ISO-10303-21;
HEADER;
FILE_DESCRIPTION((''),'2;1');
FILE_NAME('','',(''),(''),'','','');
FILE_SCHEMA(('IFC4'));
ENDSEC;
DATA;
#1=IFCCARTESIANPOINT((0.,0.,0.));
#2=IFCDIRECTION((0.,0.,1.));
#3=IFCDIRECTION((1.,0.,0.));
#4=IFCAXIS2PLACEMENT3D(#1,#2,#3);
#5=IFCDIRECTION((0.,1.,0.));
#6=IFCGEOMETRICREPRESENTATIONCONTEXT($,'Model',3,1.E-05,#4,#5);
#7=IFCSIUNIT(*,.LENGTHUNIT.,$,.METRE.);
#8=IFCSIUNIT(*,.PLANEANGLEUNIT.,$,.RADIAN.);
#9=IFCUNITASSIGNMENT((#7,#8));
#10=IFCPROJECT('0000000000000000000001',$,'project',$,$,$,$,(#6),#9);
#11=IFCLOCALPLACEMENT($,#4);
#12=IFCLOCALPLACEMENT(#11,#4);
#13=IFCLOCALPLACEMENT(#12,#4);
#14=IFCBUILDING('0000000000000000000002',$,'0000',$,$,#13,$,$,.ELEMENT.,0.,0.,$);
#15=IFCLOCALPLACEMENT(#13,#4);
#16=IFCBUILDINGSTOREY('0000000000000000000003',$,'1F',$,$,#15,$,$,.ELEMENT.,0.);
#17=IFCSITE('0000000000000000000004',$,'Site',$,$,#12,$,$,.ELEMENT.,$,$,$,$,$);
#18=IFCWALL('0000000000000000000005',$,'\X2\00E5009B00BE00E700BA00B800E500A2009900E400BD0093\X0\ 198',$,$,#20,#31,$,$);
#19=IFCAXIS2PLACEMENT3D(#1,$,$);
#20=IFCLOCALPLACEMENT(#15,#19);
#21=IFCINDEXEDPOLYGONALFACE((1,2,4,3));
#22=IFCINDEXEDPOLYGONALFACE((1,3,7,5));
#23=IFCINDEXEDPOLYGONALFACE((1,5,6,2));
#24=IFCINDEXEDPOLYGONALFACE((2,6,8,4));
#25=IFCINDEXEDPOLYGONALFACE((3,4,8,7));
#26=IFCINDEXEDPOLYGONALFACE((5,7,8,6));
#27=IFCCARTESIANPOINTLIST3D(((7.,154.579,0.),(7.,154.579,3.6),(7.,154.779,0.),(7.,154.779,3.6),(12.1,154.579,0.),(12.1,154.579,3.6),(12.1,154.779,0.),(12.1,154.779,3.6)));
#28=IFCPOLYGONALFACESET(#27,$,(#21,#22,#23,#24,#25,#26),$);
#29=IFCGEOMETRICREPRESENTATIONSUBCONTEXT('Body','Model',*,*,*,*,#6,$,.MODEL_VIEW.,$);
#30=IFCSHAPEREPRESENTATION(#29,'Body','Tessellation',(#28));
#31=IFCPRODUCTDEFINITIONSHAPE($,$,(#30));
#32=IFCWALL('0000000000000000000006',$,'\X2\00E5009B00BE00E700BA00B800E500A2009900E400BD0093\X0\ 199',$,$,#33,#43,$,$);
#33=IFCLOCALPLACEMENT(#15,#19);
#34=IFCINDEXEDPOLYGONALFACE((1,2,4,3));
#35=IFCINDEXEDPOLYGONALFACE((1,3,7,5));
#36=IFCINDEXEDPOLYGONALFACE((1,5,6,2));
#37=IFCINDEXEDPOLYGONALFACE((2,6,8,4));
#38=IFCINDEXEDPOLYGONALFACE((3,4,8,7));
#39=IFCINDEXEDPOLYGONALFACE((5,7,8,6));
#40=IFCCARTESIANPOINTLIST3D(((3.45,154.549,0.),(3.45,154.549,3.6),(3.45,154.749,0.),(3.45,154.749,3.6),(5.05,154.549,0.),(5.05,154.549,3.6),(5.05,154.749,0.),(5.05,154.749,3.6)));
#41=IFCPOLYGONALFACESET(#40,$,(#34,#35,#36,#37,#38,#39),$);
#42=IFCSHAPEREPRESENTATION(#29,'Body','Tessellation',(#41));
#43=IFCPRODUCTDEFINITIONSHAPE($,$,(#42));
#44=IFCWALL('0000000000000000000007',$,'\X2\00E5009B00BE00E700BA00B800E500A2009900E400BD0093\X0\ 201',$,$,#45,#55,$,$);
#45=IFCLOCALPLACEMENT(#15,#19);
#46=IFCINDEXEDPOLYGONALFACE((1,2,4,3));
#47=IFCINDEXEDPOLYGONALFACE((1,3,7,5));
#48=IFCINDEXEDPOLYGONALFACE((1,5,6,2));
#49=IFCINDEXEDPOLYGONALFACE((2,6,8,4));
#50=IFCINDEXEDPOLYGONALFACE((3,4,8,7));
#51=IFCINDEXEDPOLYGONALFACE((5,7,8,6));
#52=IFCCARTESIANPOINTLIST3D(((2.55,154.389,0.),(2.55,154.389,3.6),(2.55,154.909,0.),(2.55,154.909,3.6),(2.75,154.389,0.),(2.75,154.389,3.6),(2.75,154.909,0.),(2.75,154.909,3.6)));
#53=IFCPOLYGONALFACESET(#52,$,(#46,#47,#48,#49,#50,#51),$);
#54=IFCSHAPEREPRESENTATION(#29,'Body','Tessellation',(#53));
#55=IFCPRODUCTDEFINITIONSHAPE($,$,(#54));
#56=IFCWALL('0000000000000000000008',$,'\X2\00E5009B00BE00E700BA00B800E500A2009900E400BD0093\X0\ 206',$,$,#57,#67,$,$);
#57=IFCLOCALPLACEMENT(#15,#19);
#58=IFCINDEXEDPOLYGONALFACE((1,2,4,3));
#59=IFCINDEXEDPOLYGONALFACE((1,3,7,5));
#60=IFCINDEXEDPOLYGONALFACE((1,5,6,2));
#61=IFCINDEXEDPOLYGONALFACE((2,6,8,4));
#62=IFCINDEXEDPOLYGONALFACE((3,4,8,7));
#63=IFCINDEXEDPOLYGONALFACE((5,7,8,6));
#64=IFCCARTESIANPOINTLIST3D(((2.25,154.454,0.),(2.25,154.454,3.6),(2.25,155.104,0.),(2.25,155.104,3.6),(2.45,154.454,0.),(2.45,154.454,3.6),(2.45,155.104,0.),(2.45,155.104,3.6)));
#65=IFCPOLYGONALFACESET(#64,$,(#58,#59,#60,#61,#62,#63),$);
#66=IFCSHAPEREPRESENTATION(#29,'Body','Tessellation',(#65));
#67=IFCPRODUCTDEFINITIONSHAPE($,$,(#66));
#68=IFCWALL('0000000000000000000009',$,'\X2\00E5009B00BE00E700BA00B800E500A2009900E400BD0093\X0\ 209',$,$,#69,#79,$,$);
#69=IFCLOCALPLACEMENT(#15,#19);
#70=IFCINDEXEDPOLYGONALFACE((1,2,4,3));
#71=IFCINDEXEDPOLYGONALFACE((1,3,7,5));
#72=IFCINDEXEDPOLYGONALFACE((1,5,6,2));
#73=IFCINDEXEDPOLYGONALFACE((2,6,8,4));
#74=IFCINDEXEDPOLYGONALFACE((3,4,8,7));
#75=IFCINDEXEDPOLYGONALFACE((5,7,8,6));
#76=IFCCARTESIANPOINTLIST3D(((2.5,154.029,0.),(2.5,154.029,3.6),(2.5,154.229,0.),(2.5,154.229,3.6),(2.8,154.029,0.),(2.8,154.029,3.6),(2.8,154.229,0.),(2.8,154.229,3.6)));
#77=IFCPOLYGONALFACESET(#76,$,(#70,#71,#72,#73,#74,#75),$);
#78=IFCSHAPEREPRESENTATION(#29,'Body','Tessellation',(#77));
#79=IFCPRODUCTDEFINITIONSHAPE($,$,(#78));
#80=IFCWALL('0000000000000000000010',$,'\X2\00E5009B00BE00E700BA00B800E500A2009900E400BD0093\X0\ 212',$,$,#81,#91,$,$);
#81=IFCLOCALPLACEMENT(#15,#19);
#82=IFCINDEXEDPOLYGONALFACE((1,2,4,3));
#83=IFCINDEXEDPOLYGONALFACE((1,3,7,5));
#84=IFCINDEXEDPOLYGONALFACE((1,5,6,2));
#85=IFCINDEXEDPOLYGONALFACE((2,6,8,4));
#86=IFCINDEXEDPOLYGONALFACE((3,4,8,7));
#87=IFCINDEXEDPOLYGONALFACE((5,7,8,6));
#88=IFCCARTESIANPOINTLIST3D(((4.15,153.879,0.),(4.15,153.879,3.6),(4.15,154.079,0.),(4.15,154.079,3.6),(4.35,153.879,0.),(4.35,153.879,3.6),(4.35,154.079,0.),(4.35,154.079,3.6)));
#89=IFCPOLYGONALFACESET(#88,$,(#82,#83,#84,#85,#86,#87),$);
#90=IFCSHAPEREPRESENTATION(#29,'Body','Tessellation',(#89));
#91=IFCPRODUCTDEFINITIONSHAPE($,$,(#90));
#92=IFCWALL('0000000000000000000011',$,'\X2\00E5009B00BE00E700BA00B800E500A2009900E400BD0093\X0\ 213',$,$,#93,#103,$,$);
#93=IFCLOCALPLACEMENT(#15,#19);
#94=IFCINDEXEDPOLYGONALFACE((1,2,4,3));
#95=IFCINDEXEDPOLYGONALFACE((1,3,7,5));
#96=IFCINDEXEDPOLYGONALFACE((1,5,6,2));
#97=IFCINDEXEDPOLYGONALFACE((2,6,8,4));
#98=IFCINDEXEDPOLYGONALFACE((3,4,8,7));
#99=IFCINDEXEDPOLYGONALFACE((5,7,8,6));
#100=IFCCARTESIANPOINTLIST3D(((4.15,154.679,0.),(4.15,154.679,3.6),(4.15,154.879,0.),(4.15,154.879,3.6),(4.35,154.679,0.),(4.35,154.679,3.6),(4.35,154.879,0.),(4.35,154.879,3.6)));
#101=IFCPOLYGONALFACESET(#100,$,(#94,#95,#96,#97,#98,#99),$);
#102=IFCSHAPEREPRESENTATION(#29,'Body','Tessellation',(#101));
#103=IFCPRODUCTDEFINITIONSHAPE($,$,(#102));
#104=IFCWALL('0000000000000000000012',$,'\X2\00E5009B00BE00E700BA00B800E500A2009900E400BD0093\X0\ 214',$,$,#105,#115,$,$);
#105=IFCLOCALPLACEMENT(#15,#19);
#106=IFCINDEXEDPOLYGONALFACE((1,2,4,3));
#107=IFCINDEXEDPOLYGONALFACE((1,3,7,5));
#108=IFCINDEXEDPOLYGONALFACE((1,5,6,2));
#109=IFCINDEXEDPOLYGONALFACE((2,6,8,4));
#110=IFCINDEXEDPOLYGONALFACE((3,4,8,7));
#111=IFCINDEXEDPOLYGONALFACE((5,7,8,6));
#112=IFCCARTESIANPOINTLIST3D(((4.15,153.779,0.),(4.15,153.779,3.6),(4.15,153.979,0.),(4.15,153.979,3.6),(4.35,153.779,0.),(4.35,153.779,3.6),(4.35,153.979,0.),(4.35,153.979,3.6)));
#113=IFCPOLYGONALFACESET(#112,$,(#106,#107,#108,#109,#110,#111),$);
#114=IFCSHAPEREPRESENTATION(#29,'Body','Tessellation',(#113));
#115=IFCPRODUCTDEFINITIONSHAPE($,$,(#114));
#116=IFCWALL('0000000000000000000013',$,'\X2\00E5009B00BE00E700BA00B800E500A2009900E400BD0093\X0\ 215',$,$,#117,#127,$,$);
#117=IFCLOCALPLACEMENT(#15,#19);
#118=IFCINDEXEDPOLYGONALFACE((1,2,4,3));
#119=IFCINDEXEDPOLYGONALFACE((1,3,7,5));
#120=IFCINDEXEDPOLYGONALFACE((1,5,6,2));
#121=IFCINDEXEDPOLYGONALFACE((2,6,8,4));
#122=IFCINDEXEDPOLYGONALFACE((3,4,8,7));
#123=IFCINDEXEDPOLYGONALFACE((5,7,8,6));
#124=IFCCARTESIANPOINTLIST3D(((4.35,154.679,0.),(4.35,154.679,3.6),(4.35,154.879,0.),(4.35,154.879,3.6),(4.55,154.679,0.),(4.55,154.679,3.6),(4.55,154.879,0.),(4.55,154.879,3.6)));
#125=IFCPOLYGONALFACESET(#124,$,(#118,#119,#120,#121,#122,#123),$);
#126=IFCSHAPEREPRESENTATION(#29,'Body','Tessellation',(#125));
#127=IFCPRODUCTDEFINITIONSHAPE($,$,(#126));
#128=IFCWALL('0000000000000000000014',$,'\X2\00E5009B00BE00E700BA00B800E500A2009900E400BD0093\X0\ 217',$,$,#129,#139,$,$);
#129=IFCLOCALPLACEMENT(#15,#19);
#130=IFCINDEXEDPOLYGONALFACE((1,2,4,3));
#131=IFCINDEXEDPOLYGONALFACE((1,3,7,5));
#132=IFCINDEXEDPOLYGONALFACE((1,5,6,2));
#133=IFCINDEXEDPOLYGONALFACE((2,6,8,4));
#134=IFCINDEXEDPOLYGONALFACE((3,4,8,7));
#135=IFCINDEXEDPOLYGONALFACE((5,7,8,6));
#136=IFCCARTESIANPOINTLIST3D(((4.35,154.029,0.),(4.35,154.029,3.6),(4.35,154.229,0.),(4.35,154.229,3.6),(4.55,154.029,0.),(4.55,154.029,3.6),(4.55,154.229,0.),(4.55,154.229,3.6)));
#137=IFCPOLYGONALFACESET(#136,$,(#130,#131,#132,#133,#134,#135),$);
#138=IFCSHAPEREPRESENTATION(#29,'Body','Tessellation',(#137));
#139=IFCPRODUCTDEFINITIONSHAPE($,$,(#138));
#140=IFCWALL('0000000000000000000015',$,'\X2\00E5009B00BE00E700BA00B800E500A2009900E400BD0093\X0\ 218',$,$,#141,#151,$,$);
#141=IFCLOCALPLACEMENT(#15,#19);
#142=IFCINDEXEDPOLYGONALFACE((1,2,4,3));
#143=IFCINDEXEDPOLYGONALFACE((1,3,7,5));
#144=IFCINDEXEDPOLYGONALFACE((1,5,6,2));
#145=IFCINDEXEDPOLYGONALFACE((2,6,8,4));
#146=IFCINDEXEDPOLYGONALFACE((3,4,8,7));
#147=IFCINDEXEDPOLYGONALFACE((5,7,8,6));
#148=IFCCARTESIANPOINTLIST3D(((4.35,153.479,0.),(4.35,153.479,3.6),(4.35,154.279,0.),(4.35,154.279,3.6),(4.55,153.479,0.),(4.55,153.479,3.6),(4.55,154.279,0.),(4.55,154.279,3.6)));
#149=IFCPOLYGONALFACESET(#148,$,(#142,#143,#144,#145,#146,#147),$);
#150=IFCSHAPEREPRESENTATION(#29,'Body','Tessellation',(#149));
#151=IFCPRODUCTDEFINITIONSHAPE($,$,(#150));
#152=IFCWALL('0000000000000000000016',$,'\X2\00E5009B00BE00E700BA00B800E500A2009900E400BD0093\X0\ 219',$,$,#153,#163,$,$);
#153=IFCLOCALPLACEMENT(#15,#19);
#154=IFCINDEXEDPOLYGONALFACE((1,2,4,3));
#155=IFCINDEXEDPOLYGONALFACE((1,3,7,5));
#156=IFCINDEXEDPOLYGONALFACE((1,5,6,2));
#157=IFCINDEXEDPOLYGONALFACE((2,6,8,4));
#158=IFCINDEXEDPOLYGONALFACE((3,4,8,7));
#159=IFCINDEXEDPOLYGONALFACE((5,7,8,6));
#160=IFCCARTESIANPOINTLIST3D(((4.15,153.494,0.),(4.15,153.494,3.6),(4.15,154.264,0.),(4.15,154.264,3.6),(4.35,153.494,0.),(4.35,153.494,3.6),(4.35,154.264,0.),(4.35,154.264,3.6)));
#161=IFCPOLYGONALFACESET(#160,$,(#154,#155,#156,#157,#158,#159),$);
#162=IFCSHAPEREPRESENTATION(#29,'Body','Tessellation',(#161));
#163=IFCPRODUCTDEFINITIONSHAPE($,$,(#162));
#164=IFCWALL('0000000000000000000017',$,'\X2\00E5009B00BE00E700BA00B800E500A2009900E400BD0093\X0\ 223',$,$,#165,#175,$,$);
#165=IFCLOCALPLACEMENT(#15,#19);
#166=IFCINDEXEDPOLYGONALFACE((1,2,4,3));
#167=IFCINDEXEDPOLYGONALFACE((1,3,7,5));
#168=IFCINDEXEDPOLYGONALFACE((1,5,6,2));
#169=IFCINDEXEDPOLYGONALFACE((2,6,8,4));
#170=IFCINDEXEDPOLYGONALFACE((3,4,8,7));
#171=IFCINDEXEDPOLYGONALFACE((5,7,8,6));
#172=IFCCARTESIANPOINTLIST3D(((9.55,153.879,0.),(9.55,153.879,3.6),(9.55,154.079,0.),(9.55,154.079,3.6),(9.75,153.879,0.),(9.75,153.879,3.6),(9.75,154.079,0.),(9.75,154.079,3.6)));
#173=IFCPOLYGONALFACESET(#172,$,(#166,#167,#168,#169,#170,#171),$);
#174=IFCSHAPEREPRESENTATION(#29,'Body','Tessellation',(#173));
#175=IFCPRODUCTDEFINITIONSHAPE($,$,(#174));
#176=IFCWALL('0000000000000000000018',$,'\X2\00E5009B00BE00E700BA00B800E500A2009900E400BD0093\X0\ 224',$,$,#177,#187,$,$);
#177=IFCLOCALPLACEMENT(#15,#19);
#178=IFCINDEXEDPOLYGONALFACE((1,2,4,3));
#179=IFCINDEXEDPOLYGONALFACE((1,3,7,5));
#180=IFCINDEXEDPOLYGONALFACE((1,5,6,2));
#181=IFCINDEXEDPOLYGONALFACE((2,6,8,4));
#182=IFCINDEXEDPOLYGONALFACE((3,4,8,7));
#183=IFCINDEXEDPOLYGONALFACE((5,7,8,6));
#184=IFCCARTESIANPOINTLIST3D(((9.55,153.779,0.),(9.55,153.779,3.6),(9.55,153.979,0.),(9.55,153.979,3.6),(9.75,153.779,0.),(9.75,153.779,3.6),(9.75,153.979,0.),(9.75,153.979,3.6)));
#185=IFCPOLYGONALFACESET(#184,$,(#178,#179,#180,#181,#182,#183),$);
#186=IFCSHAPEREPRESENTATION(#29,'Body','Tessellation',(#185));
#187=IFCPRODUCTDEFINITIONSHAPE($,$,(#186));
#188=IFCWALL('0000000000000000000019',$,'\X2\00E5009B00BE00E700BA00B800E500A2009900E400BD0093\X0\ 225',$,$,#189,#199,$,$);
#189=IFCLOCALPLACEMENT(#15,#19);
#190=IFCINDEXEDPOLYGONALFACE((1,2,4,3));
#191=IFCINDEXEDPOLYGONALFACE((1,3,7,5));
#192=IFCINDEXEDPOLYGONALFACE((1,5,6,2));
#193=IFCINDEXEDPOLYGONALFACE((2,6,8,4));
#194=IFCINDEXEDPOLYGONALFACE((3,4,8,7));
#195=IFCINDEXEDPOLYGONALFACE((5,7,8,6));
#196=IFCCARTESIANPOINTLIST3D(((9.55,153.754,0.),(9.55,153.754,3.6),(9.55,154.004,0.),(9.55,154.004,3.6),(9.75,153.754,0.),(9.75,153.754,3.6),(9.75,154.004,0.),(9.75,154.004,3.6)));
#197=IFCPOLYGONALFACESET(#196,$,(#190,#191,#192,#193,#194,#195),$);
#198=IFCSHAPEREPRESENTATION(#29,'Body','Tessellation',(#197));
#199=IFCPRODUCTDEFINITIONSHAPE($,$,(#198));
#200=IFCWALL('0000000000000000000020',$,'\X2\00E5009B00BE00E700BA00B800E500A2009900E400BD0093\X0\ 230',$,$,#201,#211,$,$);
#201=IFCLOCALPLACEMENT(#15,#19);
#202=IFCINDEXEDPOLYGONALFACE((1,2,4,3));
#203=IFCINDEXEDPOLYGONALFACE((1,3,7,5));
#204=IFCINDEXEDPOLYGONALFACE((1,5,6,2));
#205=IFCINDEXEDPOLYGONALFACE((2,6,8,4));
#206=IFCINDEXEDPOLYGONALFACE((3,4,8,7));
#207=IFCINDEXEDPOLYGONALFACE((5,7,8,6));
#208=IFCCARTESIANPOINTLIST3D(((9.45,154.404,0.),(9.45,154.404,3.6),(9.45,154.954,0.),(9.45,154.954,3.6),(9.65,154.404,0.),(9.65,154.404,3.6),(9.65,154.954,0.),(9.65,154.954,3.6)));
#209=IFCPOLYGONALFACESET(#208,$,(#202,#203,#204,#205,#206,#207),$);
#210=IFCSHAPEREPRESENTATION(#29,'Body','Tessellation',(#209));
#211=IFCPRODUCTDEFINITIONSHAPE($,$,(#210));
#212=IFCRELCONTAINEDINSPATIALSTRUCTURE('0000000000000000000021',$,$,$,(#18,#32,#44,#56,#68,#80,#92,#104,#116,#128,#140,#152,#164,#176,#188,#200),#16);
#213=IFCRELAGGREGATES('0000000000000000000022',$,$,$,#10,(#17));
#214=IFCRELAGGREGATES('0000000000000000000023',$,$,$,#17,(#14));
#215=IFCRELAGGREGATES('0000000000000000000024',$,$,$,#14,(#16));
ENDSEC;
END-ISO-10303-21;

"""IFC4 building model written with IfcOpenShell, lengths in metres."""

from ifc_helpers import new_model, si_unit, direction, frame, frame_2d, origin_with_axes, place, context, subcontext, project, spatial, rectangle, extrude, element, save


model = new_model("IFC4")

# Units and contexts
model_context = context("Model", 3, precision=1e-05, world=origin_with_axes(), true_north=direction((0.0, 1.0, 0.0)))
body_context = subcontext(model_context, "Body", "Model", "MODEL_VIEW")
ifc_project = project(units=[si_unit("LENGTHUNIT", "METRE"), si_unit("PLANEANGLEUNIT", "RADIAN")], contexts=[model_context])

# Site, building, storey
placement = place(None, origin_with_axes())
site_placement = place(placement, origin_with_axes())
site = spatial("IfcSite", under=ifc_project, at=site_placement, Name="Site", CompositionType="ELEMENT")
building_placement = place(site_placement, origin_with_axes())
building = spatial("IfcBuilding", under=site, at=building_placement, Name="0000", CompositionType="ELEMENT", ElevationOfRefHeight=0.0, ElevationOfTerrain=0.0)
storey_placement = place(building_placement, origin_with_axes())
storey = spatial("IfcBuildingStorey", under=building, at=storey_placement, Name="1F", CompositionType="ELEMENT", Elevation=0.0)

# Walls
wall_1_placement = place(storey_placement, frame((9.55, 154.679, 0.0), z_axis=(0.0, 0.0, 1.0), x_axis=(-1.0, 0.0, 0.0)))
element("IfcWall", 1, at=wall_1_placement, inside=storey, Name="å\u009b¾çº¸å¢\u0099ä½\u0093 198", context=body_context, shape_type="SweptSolid", body=[
    extrude(rectangle(XDim=5.1, YDim=0.2, at=frame_2d((0.0, 0.0), x_axis=(1.0, 0.0, 0.0))), frame((0.0, 0.0, 0.0), z_axis=(0.0, 0.0, 1.0)), (0.0, 0.0, 1.0), 3.6),
])
wall_2_placement = place(storey_placement, frame((4.25, 154.649, 0.0), z_axis=(0.0, 0.0, 1.0), x_axis=(-1.0, 0.0, 0.0)))
element("IfcWall", 2, at=wall_2_placement, inside=storey, Name="å\u009b¾çº¸å¢\u0099ä½\u0093 199", context=body_context, shape_type="SweptSolid", body=[
    extrude(rectangle(XDim=1.6, YDim=0.2, at=frame_2d((0.0, 0.0), x_axis=(1.0, 0.0, 0.0))), frame((0.0, 0.0, 0.0), z_axis=(0.0, 0.0, 1.0)), (0.0, 0.0, 1.0), 3.6),
])
wall_3_placement = place(storey_placement, frame((2.65, 154.649, 0.0), z_axis=(0.0, 0.0, 1.0), x_axis=(0.0, -1.0, 0.0)))
element("IfcWall", 3, at=wall_3_placement, inside=storey, Name="å\u009b¾çº¸å¢\u0099ä½\u0093 201", context=body_context, shape_type="SweptSolid", body=[
    extrude(rectangle(XDim=0.52, YDim=0.2, at=frame_2d((0.0, 0.0), x_axis=(1.0, 0.0, 0.0))), frame((0.0, 0.0, 0.0), z_axis=(0.0, 0.0, 1.0)), (0.0, 0.0, 1.0), 3.6),
])
wall_4_placement = place(storey_placement, frame((2.35, 154.779, 0.0), z_axis=(0.0, 0.0, 1.0), x_axis=(0.0, -1.0, 0.0)))
element("IfcWall", 4, at=wall_4_placement, inside=storey, Name="å\u009b¾çº¸å¢\u0099ä½\u0093 206", context=body_context, shape_type="SweptSolid", body=[
    extrude(rectangle(XDim=0.65, YDim=0.2, at=frame_2d((0.0, 0.0), x_axis=(1.0, 0.0, 0.0))), frame((0.0, 0.0, 0.0), z_axis=(0.0, 0.0, 1.0)), (0.0, 0.0, 1.0), 3.6),
])
wall_5_placement = place(storey_placement, frame((2.65, 154.129, 0.0), z_axis=(0.0, 0.0, 1.0), x_axis=(-1.0, 0.0, 0.0)))
element("IfcWall", 5, at=wall_5_placement, inside=storey, Name="å\u009b¾çº¸å¢\u0099ä½\u0093 209", context=body_context, shape_type="SweptSolid", body=[
    extrude(rectangle(XDim=0.3, YDim=0.2, at=frame_2d((0.0, 0.0), x_axis=(1.0, 0.0, 0.0))), frame((0.0, 0.0, 0.0), z_axis=(0.0, 0.0, 1.0)), (0.0, 0.0, 1.0), 3.6),
])
for number, where, z_axis, x_axis, name in (
    (6, (4.25, 153.979, 0.0), (0.0, 0.0, 1.0), (1.0, 0.0, 0.0), "å\u009b¾çº¸å¢\u0099ä½\u0093 212"),
    (7, (4.25, 154.779, 0.0), (0.0, 0.0, 1.0), (1.0, 0.0, 0.0), "å\u009b¾çº¸å¢\u0099ä½\u0093 213"),
    (8, (4.25, 153.879, 0.0), (0.0, 0.0, 1.0), (1.0, 0.0, 0.0), "å\u009b¾çº¸å¢\u0099ä½\u0093 214"),
    (9, (4.45, 154.779, 0.0), (0.0, 0.0, 1.0), (-1.0, 0.0, 0.0), "å\u009b¾çº¸å¢\u0099ä½\u0093 215"),
    (10, (4.45, 154.129, 0.0), (0.0, 0.0, 1.0), (-1.0, 0.0, 0.0), "å\u009b¾çº¸å¢\u0099ä½\u0093 217"),
):
    element("IfcWall", number, at=place(storey_placement, frame(where, z_axis=z_axis, x_axis=x_axis)), inside=storey, Name=name, context=body_context, shape_type="SweptSolid", body=[
        extrude(rectangle(XDim=0.2, YDim=0.2, at=frame_2d((0.0, 0.0), x_axis=(1.0, 0.0, 0.0))), frame((0.0, 0.0, 0.0), z_axis=(0.0, 0.0, 1.0)), (0.0, 0.0, 1.0), 3.6),
    ])
wall_6_placement = place(storey_placement, frame((4.45, 153.879, 0.0), z_axis=(0.0, 0.0, 1.0), x_axis=(0.0, 1.0, 0.0)))
element("IfcWall", 11, at=wall_6_placement, inside=storey, Name="å\u009b¾çº¸å¢\u0099ä½\u0093 218", context=body_context, shape_type="SweptSolid", body=[
    extrude(rectangle(XDim=0.8, YDim=0.2, at=frame_2d((0.0, 0.0), x_axis=(1.0, 0.0, 0.0))), frame((0.0, 0.0, 0.0), z_axis=(0.0, 0.0, 1.0)), (0.0, 0.0, 1.0), 3.6),
])
wall_7_placement = place(storey_placement, frame((4.25, 153.879, 0.0), z_axis=(0.0, 0.0, 1.0), x_axis=(0.0, 1.0, 0.0)))
element("IfcWall", 12, at=wall_7_placement, inside=storey, Name="å\u009b¾çº¸å¢\u0099ä½\u0093 219", context=body_context, shape_type="SweptSolid", body=[
    extrude(rectangle(XDim=0.77, YDim=0.2, at=frame_2d((0.0, 0.0), x_axis=(1.0, 0.0, 0.0))), frame((0.0, 0.0, 0.0), z_axis=(0.0, 0.0, 1.0)), (0.0, 0.0, 1.0), 3.6),
])
for number, where, z_axis, x_axis, name in (
    (13, (9.65, 153.979, 0.0), (0.0, 0.0, 1.0), (1.0, 0.0, 0.0), "å\u009b¾çº¸å¢\u0099ä½\u0093 223"),
    (14, (9.65, 153.879, 0.0), (0.0, 0.0, 1.0), (1.0, 0.0, 0.0), "å\u009b¾çº¸å¢\u0099ä½\u0093 224"),
):
    element("IfcWall", number, at=place(storey_placement, frame(where, z_axis=z_axis, x_axis=x_axis)), inside=storey, Name=name, context=body_context, shape_type="SweptSolid", body=[
        extrude(rectangle(XDim=0.2, YDim=0.2, at=frame_2d((0.0, 0.0), x_axis=(1.0, 0.0, 0.0))), frame((0.0, 0.0, 0.0), z_axis=(0.0, 0.0, 1.0)), (0.0, 0.0, 1.0), 3.6),
    ])
wall_8_placement = place(storey_placement, frame((9.65, 153.879, 0.0), z_axis=(0.0, 0.0, 1.0), x_axis=(0.0, 1.0, 0.0)))
element("IfcWall", 15, at=wall_8_placement, inside=storey, Name="å\u009b¾çº¸å¢\u0099ä½\u0093 225", context=body_context, shape_type="SweptSolid", body=[
    extrude(rectangle(XDim=0.25, YDim=0.2, at=frame_2d((0.0, 0.0), x_axis=(1.0, 0.0, 0.0))), frame((0.0, 0.0, 0.0), z_axis=(0.0, 0.0, 1.0)), (0.0, 0.0, 1.0), 3.6),
])
wall_9_placement = place(storey_placement, frame((9.55, 154.679, 0.0), z_axis=(0.0, 0.0, 1.0), x_axis=(0.0, -1.0, 0.0)))
element("IfcWall", 16, at=wall_9_placement, inside=storey, Name="å\u009b¾çº¸å¢\u0099ä½\u0093 230", context=body_context, shape_type="SweptSolid", body=[
    extrude(rectangle(XDim=0.55, YDim=0.2, at=frame_2d((0.0, 0.0), x_axis=(1.0, 0.0, 0.0))), frame((0.0, 0.0, 0.0), z_axis=(0.0, 0.0, 1.0)), (0.0, 0.0, 1.0), 3.6),
])

save(model, "model.ifc")
